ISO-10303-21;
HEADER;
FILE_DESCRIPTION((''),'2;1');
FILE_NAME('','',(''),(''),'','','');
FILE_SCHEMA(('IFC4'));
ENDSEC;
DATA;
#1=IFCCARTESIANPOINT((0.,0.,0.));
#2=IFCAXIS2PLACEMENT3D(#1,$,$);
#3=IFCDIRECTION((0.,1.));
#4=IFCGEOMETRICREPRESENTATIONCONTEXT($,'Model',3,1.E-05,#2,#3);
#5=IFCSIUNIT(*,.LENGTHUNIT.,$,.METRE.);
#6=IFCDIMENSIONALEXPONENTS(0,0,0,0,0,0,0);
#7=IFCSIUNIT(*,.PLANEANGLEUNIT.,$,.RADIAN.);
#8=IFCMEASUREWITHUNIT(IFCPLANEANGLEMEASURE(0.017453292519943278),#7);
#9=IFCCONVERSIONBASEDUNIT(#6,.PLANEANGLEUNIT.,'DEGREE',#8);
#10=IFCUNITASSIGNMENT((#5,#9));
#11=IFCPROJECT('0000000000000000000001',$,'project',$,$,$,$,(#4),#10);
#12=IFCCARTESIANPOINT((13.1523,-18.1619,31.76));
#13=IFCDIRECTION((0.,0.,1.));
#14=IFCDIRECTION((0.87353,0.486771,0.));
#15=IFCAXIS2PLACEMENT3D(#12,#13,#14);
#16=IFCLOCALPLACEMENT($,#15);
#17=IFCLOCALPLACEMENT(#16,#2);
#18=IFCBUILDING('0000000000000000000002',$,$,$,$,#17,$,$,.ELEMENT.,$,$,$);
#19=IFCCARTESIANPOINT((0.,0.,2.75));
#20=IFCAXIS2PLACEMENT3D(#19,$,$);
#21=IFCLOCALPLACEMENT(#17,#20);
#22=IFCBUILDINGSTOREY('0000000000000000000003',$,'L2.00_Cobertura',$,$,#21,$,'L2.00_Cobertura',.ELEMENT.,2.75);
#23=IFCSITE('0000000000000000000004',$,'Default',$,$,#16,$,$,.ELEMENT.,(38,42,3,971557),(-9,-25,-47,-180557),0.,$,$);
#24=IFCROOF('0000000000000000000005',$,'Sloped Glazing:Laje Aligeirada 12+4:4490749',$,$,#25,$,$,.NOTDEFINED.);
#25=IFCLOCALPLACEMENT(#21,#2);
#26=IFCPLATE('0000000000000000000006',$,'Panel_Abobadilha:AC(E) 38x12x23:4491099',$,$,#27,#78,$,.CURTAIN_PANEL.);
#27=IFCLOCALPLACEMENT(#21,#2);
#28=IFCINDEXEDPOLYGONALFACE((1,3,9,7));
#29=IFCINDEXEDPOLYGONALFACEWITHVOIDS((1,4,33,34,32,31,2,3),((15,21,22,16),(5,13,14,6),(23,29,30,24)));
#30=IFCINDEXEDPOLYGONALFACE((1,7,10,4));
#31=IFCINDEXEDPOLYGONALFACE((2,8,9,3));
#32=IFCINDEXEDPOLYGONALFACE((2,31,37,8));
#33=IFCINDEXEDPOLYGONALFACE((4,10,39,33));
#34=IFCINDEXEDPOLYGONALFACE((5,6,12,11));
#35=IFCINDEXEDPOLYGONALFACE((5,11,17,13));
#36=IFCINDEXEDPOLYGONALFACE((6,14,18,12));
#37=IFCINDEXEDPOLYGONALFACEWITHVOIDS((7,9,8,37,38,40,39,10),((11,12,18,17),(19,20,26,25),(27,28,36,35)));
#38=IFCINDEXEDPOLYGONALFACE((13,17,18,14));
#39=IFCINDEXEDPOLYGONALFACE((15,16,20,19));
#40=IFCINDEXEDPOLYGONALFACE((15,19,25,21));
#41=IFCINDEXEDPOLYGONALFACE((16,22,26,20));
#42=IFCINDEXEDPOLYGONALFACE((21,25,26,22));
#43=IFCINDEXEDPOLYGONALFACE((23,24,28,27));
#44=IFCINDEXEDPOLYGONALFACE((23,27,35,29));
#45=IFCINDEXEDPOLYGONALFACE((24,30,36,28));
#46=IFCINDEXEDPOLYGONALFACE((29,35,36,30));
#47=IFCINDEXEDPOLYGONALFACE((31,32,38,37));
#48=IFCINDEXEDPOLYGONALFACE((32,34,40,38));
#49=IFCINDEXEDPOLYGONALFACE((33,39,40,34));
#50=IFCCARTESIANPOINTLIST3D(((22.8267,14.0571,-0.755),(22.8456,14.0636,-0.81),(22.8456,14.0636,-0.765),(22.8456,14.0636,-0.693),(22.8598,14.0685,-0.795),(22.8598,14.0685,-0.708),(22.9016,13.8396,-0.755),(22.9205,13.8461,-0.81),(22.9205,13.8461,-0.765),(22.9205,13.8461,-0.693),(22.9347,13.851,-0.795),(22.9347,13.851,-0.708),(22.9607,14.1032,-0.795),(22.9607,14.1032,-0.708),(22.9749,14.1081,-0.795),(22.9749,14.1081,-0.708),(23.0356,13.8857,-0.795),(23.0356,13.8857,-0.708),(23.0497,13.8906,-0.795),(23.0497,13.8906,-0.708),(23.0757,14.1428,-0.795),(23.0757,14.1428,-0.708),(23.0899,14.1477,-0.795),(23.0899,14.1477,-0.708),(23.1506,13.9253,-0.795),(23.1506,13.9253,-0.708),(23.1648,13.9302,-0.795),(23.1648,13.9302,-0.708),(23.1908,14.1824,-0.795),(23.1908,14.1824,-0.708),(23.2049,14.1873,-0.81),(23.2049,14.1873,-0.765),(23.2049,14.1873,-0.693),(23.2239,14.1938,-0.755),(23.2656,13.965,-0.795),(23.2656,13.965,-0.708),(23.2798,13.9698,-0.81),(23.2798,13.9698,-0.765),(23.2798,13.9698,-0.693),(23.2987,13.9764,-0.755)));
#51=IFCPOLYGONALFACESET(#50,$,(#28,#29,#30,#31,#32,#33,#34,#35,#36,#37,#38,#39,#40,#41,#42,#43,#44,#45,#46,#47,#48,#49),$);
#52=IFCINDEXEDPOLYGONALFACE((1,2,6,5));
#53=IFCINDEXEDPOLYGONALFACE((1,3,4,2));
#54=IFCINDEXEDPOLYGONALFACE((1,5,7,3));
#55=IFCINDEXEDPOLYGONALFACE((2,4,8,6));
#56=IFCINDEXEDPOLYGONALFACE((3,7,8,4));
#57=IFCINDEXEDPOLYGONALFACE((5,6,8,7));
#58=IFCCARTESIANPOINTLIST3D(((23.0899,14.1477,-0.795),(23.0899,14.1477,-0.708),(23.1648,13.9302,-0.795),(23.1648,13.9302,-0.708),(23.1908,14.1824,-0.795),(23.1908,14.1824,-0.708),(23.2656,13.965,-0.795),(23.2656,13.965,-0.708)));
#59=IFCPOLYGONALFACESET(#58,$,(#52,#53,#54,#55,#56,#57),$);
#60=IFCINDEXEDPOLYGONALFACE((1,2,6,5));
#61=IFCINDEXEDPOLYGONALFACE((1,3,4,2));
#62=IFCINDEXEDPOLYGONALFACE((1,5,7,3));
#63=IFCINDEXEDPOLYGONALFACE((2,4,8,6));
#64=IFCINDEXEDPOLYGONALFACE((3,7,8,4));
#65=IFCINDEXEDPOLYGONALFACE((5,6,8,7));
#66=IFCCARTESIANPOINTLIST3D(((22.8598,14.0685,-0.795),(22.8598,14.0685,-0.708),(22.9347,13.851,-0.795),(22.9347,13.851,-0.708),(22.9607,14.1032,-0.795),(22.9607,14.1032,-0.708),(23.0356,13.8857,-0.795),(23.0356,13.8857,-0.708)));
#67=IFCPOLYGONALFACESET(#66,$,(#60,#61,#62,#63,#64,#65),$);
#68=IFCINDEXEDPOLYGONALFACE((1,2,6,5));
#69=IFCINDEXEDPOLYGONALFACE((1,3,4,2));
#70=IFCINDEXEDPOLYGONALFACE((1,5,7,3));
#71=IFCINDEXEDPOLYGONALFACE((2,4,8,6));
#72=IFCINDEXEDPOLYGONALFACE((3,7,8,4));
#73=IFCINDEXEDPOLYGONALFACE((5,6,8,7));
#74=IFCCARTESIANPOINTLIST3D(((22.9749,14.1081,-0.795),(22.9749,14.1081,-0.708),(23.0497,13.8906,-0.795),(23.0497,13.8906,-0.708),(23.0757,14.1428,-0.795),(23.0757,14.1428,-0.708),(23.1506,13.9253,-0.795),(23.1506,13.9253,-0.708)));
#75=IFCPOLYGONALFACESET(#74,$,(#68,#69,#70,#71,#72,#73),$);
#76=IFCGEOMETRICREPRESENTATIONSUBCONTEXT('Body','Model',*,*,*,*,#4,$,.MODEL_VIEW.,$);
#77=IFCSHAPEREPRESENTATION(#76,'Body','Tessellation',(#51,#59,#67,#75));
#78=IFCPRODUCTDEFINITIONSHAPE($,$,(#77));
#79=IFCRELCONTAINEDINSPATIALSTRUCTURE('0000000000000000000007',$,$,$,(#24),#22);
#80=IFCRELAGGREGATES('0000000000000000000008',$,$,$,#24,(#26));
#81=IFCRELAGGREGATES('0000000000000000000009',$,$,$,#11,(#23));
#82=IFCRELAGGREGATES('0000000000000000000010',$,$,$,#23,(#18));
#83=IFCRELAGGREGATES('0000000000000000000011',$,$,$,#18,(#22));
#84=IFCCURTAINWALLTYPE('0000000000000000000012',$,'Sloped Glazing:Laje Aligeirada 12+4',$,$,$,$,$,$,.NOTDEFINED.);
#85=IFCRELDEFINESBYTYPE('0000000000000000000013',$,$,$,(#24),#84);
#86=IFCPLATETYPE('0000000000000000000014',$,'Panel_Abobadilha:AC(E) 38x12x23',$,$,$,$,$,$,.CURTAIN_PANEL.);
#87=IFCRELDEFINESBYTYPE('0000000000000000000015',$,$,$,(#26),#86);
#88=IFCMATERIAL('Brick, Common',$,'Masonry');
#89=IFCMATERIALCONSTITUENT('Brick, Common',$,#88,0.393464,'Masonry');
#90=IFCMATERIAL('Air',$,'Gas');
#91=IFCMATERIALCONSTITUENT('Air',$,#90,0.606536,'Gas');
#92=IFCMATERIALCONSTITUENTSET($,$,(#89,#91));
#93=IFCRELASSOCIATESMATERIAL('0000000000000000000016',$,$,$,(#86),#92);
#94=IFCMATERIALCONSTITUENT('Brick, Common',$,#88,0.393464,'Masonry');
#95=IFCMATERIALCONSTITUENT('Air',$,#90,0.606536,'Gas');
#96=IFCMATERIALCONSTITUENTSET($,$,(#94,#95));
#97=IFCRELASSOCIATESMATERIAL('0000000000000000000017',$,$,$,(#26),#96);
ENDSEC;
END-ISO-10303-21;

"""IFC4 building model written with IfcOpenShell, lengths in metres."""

from ifc_helpers import new_model, entity, si_unit, converted_unit, direction, frame, origin, place, context, subcontext, project, spatial, indexed_curve, outline, extrude, source, transform, mapped, material, constituent, constituent_set, type_object, type_shapes, element, aggregate, save


model = new_model("IFC4")

# Units and contexts
model_context = context("Model", 3, precision=1e-05, world=origin(), true_north=direction((0.0, 1.0)))
body_context = subcontext(model_context, "Body", "Model", "MODEL_VIEW")
ifc_project = project(units=[si_unit("LENGTHUNIT", "METRE"), converted_unit("PLANEANGLEUNIT", "DEGREE", entity("IfcPlaneAngleMeasure", 0.017453292519943278), si_unit("PLANEANGLEUNIT", "RADIAN"), dimensions=[0, 0, 0, 0, 0, 0, 0])], contexts=[model_context])

# Site, building, storey
site_placement = place(None, frame((13.1523, -18.1619, 31.76), z_axis=(0.0, 0.0, 1.0), x_axis=(0.87353, 0.486771, 0.0)))
site = spatial("IfcSite", under=ifc_project, at=site_placement, Name="Default", CompositionType="ELEMENT", RefLatitude=(38, 42, 3, 971557), RefLongitude=(-9, -25, -47, -180557), RefElevation=0.0)
building_placement = place(site_placement, origin())
building = spatial("IfcBuilding", under=site, at=building_placement, CompositionType="ELEMENT")
storey_placement = place(building_placement, frame((0.0, 0.0, 2.75)))
storey = spatial("IfcBuildingStorey", under=building, at=storey_placement, Name="L2.00_Cobertura", LongName="L2.00_Cobertura", CompositionType="ELEMENT", Elevation=2.75)

# Roof, plate
curtain_wall_type = type_object("IfcCurtainWallType", Name="Sloped Glazing:Laje Aligeirada 12+4", PredefinedType="NOTDEFINED")
roof_placement = place(storey_placement, frame((0.0, 0.0, -2.75)))
roof = element("IfcRoof", 1, at=roof_placement, inside=storey, type_object=curtain_wall_type, Name="Sloped Glazing:Laje Aligeirada 12+4:4490749", PredefinedType="NOTDEFINED")
ifc_material_1 = material(Name="Brick, Common", Category="Masonry")
ifc_material_2 = material(Name="Air", Category="Gas")
ifc_constituent_1 = constituent(ifc_material_1, Name="Brick, Common", Category="Masonry", fraction=0.393464)
ifc_constituent_2 = constituent(ifc_material_2, Name="Air", Category="Gas", fraction=0.606536)
ifc_constituent_set_1 = constituent_set(constituents=[ifc_constituent_1, ifc_constituent_2])
plate_type = type_object("IfcPlateType", Name="Panel_Abobadilha:AC(E) 38x12x23", PredefinedType="CURTAIN_PANEL", material=ifc_constituent_set_1)
shared_shape_1 = source(origin(), body_context, "Body", "SweptSolid", [
    extrude(outline(indexed_curve([(-0.19, -0.0543), (0.19, -0.0543), (0.19, -0.0093), (0.21, 0.0007), (0.19, 0.0628), (-0.19, 0.0628), (-0.21, 0.0007), (-0.19, -0.0093), (-0.19, -0.0543)], self_intersect=False), holes=[indexed_curve([(-0.0683, 0.0477), (-0.0683, -0.0393), (-0.175, -0.0393), (-0.175, 0.0477), (-0.0683, 0.0477)], self_intersect=False), indexed_curve([(0.0533, 0.0477), (0.0533, -0.0393), (-0.0533, -0.0393), (-0.0533, 0.0477), (0.0533, 0.0477)], self_intersect=False), indexed_curve([(0.175, 0.0477), (0.175, -0.0393), (0.0683, -0.0393), (0.0683, 0.0477), (0.175, 0.0477)], self_intersect=False)]), frame((0.0, 0.0543, 0.0)), (0.0, 0.0, 1.0), 0.23),
    extrude(outline(indexed_curve([(-0.0533, -0.0435), (0.0533, -0.0435), (0.0533, 0.0435), (-0.0533, 0.0435), (-0.0533, -0.0435)], self_intersect=False)), frame((0.1217, 0.0585, 0.0), z_axis=(0.0, 0.0, 1.0), x_axis=(-1.0, 0.0, 0.0)), (0.0, 0.0, 1.0), 0.23),
    extrude(outline(indexed_curve([(-0.0533, -0.0435), (0.0533, -0.0435), (0.0533, 0.0435), (-0.0533, 0.0435), (-0.0533, -0.0435)], self_intersect=False)), frame((-0.1217, 0.0585, 0.0), z_axis=(0.0, 0.0, 1.0), x_axis=(-1.0, 0.0, 0.0)), (0.0, 0.0, 1.0), 0.23),
    extrude(outline(indexed_curve([(-0.0533, -0.0435), (0.0533, -0.0435), (0.0533, 0.0435), (-0.0533, 0.0435), (-0.0533, -0.0435)], self_intersect=False)), frame((0.0, 0.0585, 0.0), z_axis=(0.0, 0.0, 1.0), x_axis=(-1.0, 0.0, 0.0)), (0.0, 0.0, 1.0), 0.23),
])
type_shapes(plate_type, [shared_shape_1])
ifc_constituent_3 = constituent(ifc_material_1, Name="Brick, Common", Category="Masonry", fraction=0.393464)
ifc_constituent_4 = constituent(ifc_material_2, Name="Air", Category="Gas", fraction=0.606536)
ifc_constituent_set_2 = constituent_set(constituents=[ifc_constituent_3, ifc_constituent_4])
plate_1_placement = place(roof_placement, frame((23.0253, 14.1255, 1.94), z_axis=(0.325568, -0.945519, 0.0), x_axis=(0.945519, 0.325568, 0.0)))
plate_1 = element("IfcPlate", 2, at=plate_1_placement, type_object=plate_type, material=ifc_constituent_set_2, Name="Panel_Abobadilha:AC(E) 38x12x23:4491099", PredefinedType="CURTAIN_PANEL", context=body_context, shape_type="MappedRepresentation", body=[
    mapped(shared_shape_1, transform((0.0, 0.0, 0.0), scale=1.0)),
])
aggregate(roof, [plate_1])

save(model, "model.ifc")
